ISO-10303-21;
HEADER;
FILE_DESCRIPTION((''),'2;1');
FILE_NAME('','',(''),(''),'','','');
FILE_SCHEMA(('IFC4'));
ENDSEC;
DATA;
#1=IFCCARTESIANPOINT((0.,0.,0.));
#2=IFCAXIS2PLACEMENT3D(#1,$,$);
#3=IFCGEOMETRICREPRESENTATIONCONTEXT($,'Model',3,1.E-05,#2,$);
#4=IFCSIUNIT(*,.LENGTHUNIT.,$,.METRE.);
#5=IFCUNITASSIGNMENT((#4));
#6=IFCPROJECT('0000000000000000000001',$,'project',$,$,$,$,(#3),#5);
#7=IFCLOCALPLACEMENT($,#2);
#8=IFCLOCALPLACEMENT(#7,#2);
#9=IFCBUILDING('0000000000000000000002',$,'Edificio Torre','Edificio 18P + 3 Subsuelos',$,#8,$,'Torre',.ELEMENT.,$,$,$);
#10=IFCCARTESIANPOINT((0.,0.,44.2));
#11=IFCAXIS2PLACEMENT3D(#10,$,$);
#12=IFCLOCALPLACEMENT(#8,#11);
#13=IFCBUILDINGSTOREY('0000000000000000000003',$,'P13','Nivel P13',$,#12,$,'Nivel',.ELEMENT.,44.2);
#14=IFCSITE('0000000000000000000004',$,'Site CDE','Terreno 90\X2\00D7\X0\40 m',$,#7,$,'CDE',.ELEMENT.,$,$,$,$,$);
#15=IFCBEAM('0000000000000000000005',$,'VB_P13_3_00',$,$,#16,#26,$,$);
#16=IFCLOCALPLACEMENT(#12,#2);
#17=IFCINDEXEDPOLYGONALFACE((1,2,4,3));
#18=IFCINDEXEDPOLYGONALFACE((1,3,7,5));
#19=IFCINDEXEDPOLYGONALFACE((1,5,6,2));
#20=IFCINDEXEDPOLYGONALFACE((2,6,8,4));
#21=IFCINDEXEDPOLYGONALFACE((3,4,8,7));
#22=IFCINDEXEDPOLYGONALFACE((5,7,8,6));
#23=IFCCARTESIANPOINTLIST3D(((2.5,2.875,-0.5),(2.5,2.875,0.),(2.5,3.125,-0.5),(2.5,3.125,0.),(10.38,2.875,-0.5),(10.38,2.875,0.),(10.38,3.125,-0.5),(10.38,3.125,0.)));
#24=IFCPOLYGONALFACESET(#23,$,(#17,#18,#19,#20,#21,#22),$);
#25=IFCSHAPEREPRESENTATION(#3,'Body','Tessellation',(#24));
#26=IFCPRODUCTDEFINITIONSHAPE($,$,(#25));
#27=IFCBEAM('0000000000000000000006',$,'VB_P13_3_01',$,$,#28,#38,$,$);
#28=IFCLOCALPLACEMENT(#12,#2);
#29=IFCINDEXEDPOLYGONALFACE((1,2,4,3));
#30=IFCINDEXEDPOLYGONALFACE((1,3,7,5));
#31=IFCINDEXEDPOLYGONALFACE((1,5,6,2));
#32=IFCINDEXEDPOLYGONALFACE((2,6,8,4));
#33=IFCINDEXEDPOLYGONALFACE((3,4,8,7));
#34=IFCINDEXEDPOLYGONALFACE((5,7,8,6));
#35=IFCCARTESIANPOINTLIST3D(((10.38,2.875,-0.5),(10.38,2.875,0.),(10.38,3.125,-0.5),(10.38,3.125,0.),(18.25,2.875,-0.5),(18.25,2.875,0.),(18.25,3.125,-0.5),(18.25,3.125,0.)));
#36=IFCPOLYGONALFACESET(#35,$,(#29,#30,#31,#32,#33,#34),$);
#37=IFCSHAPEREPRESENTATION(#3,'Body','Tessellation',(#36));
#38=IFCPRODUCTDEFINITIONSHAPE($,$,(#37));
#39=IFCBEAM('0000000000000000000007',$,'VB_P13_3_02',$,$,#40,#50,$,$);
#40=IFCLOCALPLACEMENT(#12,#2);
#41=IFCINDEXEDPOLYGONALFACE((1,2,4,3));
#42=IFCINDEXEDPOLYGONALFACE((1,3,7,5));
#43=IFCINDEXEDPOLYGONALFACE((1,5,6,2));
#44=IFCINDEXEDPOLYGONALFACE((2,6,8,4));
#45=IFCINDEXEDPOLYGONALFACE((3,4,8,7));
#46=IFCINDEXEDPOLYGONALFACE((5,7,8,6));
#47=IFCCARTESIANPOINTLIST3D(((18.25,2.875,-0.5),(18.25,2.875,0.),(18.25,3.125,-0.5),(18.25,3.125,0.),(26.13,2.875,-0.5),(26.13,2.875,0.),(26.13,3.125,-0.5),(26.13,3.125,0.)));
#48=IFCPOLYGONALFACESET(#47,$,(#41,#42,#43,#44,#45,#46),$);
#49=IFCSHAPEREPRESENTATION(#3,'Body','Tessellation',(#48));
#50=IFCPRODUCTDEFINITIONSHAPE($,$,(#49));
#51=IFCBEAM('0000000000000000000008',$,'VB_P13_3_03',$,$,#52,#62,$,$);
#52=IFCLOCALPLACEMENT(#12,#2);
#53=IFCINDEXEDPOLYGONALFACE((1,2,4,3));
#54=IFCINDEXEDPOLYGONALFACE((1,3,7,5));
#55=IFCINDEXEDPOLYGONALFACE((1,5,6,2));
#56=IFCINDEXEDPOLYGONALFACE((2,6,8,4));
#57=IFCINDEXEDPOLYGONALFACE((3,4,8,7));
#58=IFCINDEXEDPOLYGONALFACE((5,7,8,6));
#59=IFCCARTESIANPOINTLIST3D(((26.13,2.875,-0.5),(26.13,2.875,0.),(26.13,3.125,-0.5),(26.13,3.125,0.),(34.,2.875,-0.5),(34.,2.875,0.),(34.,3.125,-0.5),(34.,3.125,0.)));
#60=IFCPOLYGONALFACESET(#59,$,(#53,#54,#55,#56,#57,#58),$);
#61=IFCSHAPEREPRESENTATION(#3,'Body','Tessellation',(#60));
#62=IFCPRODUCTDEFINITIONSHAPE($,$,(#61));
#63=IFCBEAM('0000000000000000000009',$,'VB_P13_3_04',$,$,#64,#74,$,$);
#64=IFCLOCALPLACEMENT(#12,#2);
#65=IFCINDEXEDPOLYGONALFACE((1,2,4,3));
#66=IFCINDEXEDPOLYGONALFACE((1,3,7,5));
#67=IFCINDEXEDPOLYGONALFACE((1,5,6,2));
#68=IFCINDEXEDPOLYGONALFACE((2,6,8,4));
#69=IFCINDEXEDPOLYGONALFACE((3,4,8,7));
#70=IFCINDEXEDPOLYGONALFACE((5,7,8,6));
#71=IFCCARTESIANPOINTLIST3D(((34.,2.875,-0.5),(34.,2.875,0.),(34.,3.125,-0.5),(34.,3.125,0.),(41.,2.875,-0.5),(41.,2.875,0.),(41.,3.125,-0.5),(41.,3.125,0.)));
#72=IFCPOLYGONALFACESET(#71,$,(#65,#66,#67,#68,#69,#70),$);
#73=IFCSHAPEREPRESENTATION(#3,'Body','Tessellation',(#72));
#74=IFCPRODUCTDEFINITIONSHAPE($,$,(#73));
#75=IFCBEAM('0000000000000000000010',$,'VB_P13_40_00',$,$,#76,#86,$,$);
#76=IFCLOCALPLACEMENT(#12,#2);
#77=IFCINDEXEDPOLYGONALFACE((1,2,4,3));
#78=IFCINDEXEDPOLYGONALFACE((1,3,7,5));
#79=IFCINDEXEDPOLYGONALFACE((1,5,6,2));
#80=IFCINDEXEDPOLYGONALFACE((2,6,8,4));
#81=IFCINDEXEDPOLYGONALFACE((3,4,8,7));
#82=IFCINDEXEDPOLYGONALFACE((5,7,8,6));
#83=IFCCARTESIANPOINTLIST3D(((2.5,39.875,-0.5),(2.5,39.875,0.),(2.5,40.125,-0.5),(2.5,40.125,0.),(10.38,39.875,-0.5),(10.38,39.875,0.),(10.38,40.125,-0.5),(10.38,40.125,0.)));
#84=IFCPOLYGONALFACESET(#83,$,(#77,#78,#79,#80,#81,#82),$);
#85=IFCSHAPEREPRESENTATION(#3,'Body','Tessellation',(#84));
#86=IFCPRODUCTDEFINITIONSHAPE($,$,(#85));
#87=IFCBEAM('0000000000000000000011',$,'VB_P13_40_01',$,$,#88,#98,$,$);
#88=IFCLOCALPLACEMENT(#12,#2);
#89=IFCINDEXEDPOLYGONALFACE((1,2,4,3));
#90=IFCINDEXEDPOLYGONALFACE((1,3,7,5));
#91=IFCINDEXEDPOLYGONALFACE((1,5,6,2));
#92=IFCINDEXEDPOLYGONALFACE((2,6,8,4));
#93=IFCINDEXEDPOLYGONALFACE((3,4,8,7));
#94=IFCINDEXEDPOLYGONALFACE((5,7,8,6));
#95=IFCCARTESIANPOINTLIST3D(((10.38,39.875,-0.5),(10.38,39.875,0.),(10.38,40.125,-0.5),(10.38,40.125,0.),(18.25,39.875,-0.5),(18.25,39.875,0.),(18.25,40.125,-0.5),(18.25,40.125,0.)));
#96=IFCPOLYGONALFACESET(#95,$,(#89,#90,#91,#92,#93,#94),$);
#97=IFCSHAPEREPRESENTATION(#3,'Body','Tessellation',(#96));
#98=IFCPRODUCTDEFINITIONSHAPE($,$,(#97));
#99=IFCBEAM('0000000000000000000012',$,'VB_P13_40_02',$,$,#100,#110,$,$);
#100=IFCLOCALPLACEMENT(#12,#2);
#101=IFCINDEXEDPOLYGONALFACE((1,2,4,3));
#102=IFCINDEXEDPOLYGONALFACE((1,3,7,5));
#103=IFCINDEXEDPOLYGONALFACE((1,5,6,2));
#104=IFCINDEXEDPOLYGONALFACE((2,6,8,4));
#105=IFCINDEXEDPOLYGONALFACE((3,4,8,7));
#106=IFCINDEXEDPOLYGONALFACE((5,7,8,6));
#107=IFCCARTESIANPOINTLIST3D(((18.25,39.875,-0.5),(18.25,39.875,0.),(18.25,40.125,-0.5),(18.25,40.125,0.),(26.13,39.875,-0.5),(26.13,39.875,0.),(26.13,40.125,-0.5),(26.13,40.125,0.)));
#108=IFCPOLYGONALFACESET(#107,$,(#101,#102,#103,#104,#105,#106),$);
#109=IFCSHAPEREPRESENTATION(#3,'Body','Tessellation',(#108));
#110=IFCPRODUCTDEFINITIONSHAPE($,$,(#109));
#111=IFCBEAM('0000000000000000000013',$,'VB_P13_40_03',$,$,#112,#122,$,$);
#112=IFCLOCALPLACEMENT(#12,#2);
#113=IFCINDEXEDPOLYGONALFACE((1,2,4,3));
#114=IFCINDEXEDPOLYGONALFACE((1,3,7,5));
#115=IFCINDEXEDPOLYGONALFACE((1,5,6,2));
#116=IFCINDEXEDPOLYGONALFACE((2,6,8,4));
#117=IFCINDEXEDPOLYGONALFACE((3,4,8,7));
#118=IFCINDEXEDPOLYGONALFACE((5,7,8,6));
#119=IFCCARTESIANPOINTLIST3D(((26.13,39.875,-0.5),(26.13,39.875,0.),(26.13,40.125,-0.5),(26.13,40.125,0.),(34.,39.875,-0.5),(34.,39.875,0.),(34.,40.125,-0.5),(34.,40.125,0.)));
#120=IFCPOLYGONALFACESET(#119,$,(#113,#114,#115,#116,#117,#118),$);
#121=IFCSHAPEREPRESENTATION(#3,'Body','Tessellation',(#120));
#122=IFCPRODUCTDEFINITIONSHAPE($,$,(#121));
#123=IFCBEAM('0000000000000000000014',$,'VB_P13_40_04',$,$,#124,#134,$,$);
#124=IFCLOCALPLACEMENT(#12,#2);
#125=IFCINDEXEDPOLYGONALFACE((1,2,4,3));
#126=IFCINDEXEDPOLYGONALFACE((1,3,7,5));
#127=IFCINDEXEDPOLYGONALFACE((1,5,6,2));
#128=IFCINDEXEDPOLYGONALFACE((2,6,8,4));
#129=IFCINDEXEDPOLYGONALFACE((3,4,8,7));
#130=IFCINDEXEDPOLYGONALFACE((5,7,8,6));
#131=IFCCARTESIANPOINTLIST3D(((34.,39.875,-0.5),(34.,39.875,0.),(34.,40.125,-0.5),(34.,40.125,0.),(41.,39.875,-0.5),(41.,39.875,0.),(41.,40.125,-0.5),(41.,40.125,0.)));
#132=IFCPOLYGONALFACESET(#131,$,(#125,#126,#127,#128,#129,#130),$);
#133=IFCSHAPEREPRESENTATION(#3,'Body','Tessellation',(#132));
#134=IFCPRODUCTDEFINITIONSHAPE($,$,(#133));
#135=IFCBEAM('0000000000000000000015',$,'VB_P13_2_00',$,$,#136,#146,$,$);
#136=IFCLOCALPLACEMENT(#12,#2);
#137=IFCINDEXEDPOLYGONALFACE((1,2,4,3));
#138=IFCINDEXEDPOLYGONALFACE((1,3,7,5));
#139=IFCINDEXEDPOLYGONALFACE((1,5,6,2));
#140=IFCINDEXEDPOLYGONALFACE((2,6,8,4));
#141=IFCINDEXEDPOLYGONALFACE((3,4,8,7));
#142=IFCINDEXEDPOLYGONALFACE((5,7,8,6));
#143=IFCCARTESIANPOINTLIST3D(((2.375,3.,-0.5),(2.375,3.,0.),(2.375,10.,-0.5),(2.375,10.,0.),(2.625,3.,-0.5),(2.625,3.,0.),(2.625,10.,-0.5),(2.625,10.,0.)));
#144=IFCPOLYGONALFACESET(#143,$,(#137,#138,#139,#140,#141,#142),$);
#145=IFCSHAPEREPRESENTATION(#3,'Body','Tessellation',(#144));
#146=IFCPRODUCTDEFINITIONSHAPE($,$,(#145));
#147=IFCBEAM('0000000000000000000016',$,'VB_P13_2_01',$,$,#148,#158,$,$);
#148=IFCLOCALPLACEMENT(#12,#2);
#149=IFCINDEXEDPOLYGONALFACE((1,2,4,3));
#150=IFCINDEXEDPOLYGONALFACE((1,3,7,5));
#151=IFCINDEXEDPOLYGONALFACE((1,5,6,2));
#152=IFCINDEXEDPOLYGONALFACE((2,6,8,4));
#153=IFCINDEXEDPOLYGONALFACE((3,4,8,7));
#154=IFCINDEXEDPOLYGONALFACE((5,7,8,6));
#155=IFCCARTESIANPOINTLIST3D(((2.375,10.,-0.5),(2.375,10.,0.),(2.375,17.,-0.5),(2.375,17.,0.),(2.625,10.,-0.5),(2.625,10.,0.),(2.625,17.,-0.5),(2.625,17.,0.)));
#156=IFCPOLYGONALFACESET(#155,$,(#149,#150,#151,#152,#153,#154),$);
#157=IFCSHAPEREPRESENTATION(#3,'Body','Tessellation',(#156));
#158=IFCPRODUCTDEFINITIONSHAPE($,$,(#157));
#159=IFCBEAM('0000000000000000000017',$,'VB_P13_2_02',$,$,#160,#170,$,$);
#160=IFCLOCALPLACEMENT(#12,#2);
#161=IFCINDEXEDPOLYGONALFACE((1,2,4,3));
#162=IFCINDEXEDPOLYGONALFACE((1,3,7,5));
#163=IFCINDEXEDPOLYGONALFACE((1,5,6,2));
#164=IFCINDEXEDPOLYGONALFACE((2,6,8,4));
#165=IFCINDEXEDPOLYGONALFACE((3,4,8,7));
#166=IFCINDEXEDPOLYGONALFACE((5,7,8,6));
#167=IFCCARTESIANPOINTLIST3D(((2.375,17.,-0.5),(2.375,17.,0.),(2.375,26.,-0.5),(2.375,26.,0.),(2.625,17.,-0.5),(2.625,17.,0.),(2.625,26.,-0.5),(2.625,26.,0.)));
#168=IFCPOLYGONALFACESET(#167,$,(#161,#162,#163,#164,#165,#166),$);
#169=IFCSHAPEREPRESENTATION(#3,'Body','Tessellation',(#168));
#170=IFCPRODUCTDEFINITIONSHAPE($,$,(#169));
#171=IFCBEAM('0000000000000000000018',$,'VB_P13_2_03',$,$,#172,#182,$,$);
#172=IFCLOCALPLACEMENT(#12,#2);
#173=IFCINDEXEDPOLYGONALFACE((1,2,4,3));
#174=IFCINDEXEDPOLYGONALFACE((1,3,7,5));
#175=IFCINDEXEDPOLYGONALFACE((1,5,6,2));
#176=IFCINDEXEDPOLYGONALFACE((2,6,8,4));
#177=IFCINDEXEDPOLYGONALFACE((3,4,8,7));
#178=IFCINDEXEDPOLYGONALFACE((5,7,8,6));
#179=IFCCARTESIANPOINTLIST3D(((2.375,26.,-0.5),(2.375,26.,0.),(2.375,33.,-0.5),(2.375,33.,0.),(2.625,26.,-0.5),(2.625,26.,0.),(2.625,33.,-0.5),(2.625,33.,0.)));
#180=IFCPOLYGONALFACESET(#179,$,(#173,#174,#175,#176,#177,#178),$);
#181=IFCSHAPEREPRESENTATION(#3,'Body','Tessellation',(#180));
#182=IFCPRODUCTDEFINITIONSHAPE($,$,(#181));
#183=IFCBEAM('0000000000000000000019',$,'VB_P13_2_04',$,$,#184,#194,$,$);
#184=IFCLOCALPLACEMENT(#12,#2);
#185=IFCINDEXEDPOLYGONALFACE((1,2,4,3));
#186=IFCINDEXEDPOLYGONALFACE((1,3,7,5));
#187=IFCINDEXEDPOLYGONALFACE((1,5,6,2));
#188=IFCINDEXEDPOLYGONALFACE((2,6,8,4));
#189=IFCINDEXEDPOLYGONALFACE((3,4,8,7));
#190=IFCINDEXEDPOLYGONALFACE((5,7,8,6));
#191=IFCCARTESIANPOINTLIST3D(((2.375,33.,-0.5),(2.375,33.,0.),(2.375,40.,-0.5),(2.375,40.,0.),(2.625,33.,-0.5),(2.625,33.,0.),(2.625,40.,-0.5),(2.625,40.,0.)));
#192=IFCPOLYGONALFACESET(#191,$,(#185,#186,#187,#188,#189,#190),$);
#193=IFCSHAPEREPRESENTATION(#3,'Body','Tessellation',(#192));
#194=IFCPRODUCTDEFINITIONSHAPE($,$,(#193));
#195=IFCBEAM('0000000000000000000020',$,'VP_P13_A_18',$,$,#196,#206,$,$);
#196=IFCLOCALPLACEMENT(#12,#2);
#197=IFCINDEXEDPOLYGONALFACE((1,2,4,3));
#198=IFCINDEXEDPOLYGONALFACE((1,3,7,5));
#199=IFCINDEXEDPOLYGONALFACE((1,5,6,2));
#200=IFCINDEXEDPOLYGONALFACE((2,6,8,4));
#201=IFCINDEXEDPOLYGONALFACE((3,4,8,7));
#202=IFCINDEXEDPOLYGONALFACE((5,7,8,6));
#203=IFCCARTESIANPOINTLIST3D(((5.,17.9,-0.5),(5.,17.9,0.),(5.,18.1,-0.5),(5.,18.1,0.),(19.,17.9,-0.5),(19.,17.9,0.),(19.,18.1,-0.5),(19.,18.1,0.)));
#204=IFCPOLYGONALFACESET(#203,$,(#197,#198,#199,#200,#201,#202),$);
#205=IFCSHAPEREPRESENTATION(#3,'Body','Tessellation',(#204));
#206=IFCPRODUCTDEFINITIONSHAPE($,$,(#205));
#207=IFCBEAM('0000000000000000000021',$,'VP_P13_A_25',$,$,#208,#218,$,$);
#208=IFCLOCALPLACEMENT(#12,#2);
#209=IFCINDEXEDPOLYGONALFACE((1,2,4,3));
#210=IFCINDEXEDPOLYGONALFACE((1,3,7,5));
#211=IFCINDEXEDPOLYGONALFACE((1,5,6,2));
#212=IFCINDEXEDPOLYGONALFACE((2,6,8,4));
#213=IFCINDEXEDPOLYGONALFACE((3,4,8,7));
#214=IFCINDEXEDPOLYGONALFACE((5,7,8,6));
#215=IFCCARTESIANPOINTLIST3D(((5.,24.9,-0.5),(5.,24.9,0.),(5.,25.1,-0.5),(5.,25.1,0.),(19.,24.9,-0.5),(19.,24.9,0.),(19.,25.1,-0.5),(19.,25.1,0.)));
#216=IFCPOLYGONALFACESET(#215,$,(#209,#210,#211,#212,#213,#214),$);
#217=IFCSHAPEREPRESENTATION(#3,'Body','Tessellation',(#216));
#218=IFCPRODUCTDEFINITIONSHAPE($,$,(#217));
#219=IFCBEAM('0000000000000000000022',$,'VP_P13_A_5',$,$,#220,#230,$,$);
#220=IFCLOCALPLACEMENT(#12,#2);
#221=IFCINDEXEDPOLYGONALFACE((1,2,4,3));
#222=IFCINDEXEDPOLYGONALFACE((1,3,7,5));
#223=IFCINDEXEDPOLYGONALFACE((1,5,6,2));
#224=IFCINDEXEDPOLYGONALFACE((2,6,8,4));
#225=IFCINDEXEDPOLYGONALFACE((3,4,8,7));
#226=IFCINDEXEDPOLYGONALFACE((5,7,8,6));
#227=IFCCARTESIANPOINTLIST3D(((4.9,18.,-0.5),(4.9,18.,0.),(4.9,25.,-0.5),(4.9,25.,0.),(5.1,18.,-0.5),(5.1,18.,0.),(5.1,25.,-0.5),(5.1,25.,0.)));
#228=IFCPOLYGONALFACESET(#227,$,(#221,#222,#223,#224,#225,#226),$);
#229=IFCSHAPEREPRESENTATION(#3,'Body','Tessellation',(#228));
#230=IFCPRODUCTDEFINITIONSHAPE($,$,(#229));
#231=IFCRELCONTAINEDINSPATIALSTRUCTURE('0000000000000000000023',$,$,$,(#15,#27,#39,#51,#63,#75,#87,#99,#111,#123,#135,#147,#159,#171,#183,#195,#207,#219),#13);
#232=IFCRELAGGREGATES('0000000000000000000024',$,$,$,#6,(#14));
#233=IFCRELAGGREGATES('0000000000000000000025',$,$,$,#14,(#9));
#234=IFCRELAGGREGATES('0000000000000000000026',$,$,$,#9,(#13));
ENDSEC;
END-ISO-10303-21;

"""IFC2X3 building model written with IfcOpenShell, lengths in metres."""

from ifc_helpers import new_model, si_unit, frame, origin, origin_2d, place, context, project, spatial, rectangle, extrude, element, save


model = new_model("IFC2X3")

# Units and contexts
model_context = context("Model", 3, precision=1e-05, world=origin())
ifc_project = project(units=[si_unit("LENGTHUNIT", "METRE")], contexts=[model_context])

# Site, building, storey
site_placement = place(None, origin())
site = spatial("IfcSite", under=ifc_project, at=site_placement, Name="Site CDE", Description="Terreno 90×40 m", LongName="CDE", CompositionType="ELEMENT")
building_placement = place(site_placement, origin())
building = spatial("IfcBuilding", under=site, at=building_placement, Name="Edificio Torre", Description="Edificio 18P + 3 Subsuelos", LongName="Torre", CompositionType="ELEMENT")
storey_placement = place(building_placement, frame((0.0, 0.0, 44.2)))
storey = spatial("IfcBuildingStorey", under=building, at=storey_placement, Name="P13", Description="Nivel P13", LongName="Nivel", CompositionType="ELEMENT", Elevation=44.2)

# Beams
beam_1_placement = place(storey_placement, frame((6.44, 3.0, -0.5)))
element("IfcBeam", 1, at=beam_1_placement, inside=storey, Name="VB_P13_3_00", context=model_context, shape_type="SweptSolid", body=[
    extrude(rectangle(XDim=7.88, YDim=0.25, at=origin_2d()), origin(), (0.0, 0.0, 1.0), 0.5),
])
beam_2_placement = place(storey_placement, frame((14.315, 3.0, -0.5)))
element("IfcBeam", 2, at=beam_2_placement, inside=storey, Name="VB_P13_3_01", context=model_context, shape_type="SweptSolid", body=[
    extrude(rectangle(XDim=7.87, YDim=0.25, at=origin_2d()), origin(), (0.0, 0.0, 1.0), 0.5),
])
beam_3_placement = place(storey_placement, frame((22.19, 3.0, -0.5)))
element("IfcBeam", 3, at=beam_3_placement, inside=storey, Name="VB_P13_3_02", context=model_context, shape_type="SweptSolid", body=[
    extrude(rectangle(XDim=7.88, YDim=0.25, at=origin_2d()), origin(), (0.0, 0.0, 1.0), 0.5),
])
beam_4_placement = place(storey_placement, frame((30.065, 3.0, -0.5)))
element("IfcBeam", 4, at=beam_4_placement, inside=storey, Name="VB_P13_3_03", context=model_context, shape_type="SweptSolid", body=[
    extrude(rectangle(XDim=7.87, YDim=0.25, at=origin_2d()), origin(), (0.0, 0.0, 1.0), 0.5),
])
beam_5_placement = place(storey_placement, frame((37.5, 3.0, -0.5)))
element("IfcBeam", 5, at=beam_5_placement, inside=storey, Name="VB_P13_3_04", context=model_context, shape_type="SweptSolid", body=[
    extrude(rectangle(XDim=7.0, YDim=0.25, at=origin_2d()), origin(), (0.0, 0.0, 1.0), 0.5),
])
beam_6_placement = place(storey_placement, frame((6.44, 40.0, -0.5)))
element("IfcBeam", 6, at=beam_6_placement, inside=storey, Name="VB_P13_40_00", context=model_context, shape_type="SweptSolid", body=[
    extrude(rectangle(XDim=7.88, YDim=0.25, at=origin_2d()), origin(), (0.0, 0.0, 1.0), 0.5),
])
beam_7_placement = place(storey_placement, frame((14.315, 40.0, -0.5)))
element("IfcBeam", 7, at=beam_7_placement, inside=storey, Name="VB_P13_40_01", context=model_context, shape_type="SweptSolid", body=[
    extrude(rectangle(XDim=7.87, YDim=0.25, at=origin_2d()), origin(), (0.0, 0.0, 1.0), 0.5),
])
beam_8_placement = place(storey_placement, frame((22.19, 40.0, -0.5)))
element("IfcBeam", 8, at=beam_8_placement, inside=storey, Name="VB_P13_40_02", context=model_context, shape_type="SweptSolid", body=[
    extrude(rectangle(XDim=7.88, YDim=0.25, at=origin_2d()), origin(), (0.0, 0.0, 1.0), 0.5),
])
beam_9_placement = place(storey_placement, frame((30.065, 40.0, -0.5)))
element("IfcBeam", 9, at=beam_9_placement, inside=storey, Name="VB_P13_40_03", context=model_context, shape_type="SweptSolid", body=[
    extrude(rectangle(XDim=7.87, YDim=0.25, at=origin_2d()), origin(), (0.0, 0.0, 1.0), 0.5),
])
beam_10_placement = place(storey_placement, frame((37.5, 40.0, -0.5)))
element("IfcBeam", 10, at=beam_10_placement, inside=storey, Name="VB_P13_40_04", context=model_context, shape_type="SweptSolid", body=[
    extrude(rectangle(XDim=7.0, YDim=0.25, at=origin_2d()), origin(), (0.0, 0.0, 1.0), 0.5),
])
for number, where, name in (
    (11, (2.5, 6.5, -0.5), "VB_P13_2_00"),
    (12, (2.5, 13.5, -0.5), "VB_P13_2_01"),
):
    element("IfcBeam", number, at=place(storey_placement, frame(where)), inside=storey, Name=name, context=model_context, shape_type="SweptSolid", body=[
        extrude(rectangle(XDim=0.25, YDim=7.0, at=origin_2d()), origin(), (0.0, 0.0, 1.0), 0.5),
    ])
beam_11_placement = place(storey_placement, frame((2.5, 21.5, -0.5)))
element("IfcBeam", 13, at=beam_11_placement, inside=storey, Name="VB_P13_2_02", context=model_context, shape_type="SweptSolid", body=[
    extrude(rectangle(XDim=0.25, YDim=9.0, at=origin_2d()), origin(), (0.0, 0.0, 1.0), 0.5),
])
for number, where, name in (
    (14, (2.5, 29.5, -0.5), "VB_P13_2_03"),
    (15, (2.5, 36.5, -0.5), "VB_P13_2_04"),
):
    element("IfcBeam", number, at=place(storey_placement, frame(where)), inside=storey, Name=name, context=model_context, shape_type="SweptSolid", body=[
        extrude(rectangle(XDim=0.25, YDim=7.0, at=origin_2d()), origin(), (0.0, 0.0, 1.0), 0.5),
    ])
for number, where, name in (
    (16, (12.0, 18.0, -0.5), "VP_P13_A_18"),
    (17, (12.0, 25.0, -0.5), "VP_P13_A_25"),
):
    element("IfcBeam", number, at=place(storey_placement, frame(where)), inside=storey, Name=name, context=model_context, shape_type="SweptSolid", body=[
        extrude(rectangle(XDim=14.0, YDim=0.2, at=origin_2d()), origin(), (0.0, 0.0, 1.0), 0.5),
    ])
beam_12_placement = place(storey_placement, frame((5.0, 21.5, -0.5)))
element("IfcBeam", 18, at=beam_12_placement, inside=storey, Name="VP_P13_A_5", context=model_context, shape_type="SweptSolid", body=[
    extrude(rectangle(XDim=0.2, YDim=7.0, at=origin_2d()), origin(), (0.0, 0.0, 1.0), 0.5),
])

save(model, "model.ifc")
